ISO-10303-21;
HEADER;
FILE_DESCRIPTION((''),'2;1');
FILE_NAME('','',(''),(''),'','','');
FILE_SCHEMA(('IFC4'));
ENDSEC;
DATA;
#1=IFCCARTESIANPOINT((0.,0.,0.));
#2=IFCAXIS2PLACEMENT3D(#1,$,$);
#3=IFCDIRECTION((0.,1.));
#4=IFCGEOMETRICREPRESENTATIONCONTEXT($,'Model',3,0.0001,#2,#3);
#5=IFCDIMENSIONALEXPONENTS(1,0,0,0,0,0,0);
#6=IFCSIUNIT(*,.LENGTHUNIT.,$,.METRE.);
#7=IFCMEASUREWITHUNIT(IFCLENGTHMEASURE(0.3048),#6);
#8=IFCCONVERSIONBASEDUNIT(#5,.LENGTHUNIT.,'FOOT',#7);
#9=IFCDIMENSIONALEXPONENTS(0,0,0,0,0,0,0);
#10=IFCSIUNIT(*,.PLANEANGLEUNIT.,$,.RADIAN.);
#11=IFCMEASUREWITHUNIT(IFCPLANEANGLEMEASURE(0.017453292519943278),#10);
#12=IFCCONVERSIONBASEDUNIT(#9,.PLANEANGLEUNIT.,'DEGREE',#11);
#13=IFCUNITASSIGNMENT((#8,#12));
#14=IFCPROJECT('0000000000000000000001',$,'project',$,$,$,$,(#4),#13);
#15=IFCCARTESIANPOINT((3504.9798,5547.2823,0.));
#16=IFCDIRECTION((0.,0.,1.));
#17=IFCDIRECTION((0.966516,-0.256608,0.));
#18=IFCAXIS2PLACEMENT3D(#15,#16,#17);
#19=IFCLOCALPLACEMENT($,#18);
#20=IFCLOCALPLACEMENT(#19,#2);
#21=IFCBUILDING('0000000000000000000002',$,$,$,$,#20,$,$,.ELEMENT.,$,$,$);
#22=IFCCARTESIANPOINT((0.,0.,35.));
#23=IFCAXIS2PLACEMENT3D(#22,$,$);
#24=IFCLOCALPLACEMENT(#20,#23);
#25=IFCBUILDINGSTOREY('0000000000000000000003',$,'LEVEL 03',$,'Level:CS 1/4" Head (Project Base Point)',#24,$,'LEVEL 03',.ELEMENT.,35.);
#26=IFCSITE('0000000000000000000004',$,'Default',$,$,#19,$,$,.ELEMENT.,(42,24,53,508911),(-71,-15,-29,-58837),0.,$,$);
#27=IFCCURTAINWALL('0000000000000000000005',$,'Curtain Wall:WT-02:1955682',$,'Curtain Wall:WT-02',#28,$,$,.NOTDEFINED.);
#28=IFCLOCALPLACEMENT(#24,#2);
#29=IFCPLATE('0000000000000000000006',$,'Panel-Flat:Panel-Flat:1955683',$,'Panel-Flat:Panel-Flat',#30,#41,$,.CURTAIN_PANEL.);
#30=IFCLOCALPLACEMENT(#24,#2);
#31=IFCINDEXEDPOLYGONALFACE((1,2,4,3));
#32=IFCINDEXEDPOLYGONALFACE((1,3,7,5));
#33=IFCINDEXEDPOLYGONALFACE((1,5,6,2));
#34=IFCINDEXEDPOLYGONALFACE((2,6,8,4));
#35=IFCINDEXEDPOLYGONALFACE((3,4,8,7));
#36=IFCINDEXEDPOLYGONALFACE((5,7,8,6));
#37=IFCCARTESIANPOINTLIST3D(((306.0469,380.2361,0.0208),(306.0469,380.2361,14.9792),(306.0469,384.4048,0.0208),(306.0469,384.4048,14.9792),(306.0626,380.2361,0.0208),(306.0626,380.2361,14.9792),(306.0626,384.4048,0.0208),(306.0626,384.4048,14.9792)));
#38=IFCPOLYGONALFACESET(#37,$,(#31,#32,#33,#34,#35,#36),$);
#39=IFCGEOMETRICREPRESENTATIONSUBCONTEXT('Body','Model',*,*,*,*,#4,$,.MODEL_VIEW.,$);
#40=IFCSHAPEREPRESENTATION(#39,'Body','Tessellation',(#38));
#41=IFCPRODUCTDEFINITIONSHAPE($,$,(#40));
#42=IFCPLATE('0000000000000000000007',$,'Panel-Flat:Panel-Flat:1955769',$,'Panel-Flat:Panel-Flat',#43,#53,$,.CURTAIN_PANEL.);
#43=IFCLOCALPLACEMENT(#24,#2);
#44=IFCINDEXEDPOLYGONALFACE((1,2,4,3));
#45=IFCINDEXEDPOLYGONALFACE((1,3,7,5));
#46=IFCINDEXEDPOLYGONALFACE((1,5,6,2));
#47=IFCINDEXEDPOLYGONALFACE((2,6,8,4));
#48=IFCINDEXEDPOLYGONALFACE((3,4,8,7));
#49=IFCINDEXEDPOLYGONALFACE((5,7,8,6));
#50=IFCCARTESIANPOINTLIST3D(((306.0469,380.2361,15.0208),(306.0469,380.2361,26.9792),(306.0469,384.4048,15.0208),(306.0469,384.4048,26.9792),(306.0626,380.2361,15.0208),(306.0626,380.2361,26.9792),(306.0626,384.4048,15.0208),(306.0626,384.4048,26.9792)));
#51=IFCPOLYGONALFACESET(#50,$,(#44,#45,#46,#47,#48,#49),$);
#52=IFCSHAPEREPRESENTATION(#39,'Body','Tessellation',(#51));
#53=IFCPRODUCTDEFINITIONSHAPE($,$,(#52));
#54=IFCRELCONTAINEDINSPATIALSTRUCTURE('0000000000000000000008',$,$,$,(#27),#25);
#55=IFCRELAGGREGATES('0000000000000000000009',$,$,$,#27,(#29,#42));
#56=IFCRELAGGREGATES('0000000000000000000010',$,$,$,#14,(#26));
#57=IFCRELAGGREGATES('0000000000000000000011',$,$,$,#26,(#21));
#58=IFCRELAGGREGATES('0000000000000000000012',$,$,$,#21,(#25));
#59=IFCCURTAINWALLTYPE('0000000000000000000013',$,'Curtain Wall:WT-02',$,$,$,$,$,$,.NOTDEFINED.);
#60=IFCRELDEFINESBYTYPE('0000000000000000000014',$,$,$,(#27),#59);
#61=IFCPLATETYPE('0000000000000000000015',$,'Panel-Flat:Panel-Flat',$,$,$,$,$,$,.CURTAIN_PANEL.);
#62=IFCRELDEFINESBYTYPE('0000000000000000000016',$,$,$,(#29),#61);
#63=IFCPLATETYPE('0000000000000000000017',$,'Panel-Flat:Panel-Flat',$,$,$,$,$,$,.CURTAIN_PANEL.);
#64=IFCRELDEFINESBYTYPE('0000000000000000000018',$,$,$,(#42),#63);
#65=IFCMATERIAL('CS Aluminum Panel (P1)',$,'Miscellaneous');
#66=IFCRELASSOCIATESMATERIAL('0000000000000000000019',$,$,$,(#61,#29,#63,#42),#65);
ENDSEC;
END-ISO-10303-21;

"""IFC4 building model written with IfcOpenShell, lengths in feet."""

from ifc_helpers import new_model, entity, si_unit, converted_unit, direction, frame, origin, place, context, subcontext, project, spatial, indexed_curve, outline, extrude, source, transform, mapped, material, type_object, type_shapes, element, aggregate, save


model = new_model("IFC4")

# Units and contexts
model_context = context("Model", 3, precision=0.0001, world=origin(), true_north=direction((0.0, 1.0)))
body_context = subcontext(model_context, "Body", "Model", "MODEL_VIEW")
ifc_project = project(units=[converted_unit("LENGTHUNIT", "FOOT", entity("IfcLengthMeasure", 0.3048), si_unit("LENGTHUNIT", "METRE"), dimensions=[1, 0, 0, 0, 0, 0, 0]), converted_unit("PLANEANGLEUNIT", "DEGREE", entity("IfcPlaneAngleMeasure", 0.017453292519943278), si_unit("PLANEANGLEUNIT", "RADIAN"), dimensions=[0, 0, 0, 0, 0, 0, 0])], contexts=[model_context])

# Site, building, storey
site_placement = place(None, frame((3504.9798, 5547.2823, 0.0), z_axis=(0.0, 0.0, 1.0), x_axis=(0.966516, -0.256608, 0.0)))
site = spatial("IfcSite", under=ifc_project, at=site_placement, Name="Default", CompositionType="ELEMENT", RefLatitude=(42, 24, 53, 508911), RefLongitude=(-71, -15, -29, -58837), RefElevation=0.0)
building_placement = place(site_placement, origin())
building = spatial("IfcBuilding", under=site, at=building_placement, CompositionType="ELEMENT")
storey_placement = place(building_placement, frame((0.0, 0.0, 35.0)))
storey = spatial("IfcBuildingStorey", under=building, at=storey_placement, Name="LEVEL 03", ObjectType="Level:CS 1/4\" Head (Project Base Point)", LongName="LEVEL 03", CompositionType="ELEMENT", Elevation=35.0)

# Curtain wall, plates
curtain_wall_type = type_object("IfcCurtainWallType", Name="Curtain Wall:WT-02", PredefinedType="NOTDEFINED")
ifc_material_1 = material(Name="CS Aluminum Panel (P1)", Category="Miscellaneous")
curtain_wall_1_placement = place(storey_placement, frame((0.0, 0.0, -35.0)))
curtain_wall_1 = element("IfcCurtainWall", 1, at=curtain_wall_1_placement, inside=storey, type_object=curtain_wall_type, Name="Curtain Wall:WT-02:1955682", ObjectType="Curtain Wall:WT-02", PredefinedType="NOTDEFINED")
plate_type_1 = type_object("IfcPlateType", Name="Panel-Flat:Panel-Flat", PredefinedType="CURTAIN_PANEL", material=ifc_material_1)
shared_shape_1 = source(origin(), body_context, "Body", "SweptSolid", [
    extrude(outline(indexed_curve([(-0.0078, -2.0843), (0.0078, -2.0843), (0.0078, 2.0843), (-0.0078, 2.0843), (-0.0078, -2.0843)], self_intersect=False)), frame((0.0, -0.0078, 0.0208), z_axis=(0.0, 0.0, 1.0), x_axis=(0.0, -1.0, 0.0)), (0.0, 0.0, 1.0), 14.9583),
])
type_shapes(plate_type_1, [shared_shape_1])
plate_1_placement = place(curtain_wall_1_placement, frame((306.0469, 382.3205, 35.0), z_axis=(0.0, 0.0, 1.0), x_axis=(0.0, 1.0, 0.0)))
plate_1 = element("IfcPlate", 2, at=plate_1_placement, type_object=plate_type_1, material=ifc_material_1, Name="Panel-Flat:Panel-Flat:1955683", ObjectType="Panel-Flat:Panel-Flat", PredefinedType="CURTAIN_PANEL", context=body_context, shape_type="MappedRepresentation", body=[
    mapped(shared_shape_1, transform((0.0, 0.0, 0.0), scale=1.0)),
])
plate_type_2 = type_object("IfcPlateType", Name="Panel-Flat:Panel-Flat", PredefinedType="CURTAIN_PANEL", material=ifc_material_1)
shared_shape_2 = source(origin(), body_context, "Body", "SweptSolid", [
    extrude(outline(indexed_curve([(-0.0078, -2.0843), (0.0078, -2.0843), (0.0078, 2.0843), (-0.0078, 2.0843), (-0.0078, -2.0843)], self_intersect=False)), frame((0.0, -0.0078, 0.0208), z_axis=(0.0, 0.0, 1.0), x_axis=(0.0, -1.0, 0.0)), (0.0, 0.0, 1.0), 11.9583),
])
type_shapes(plate_type_2, [shared_shape_2])
plate_2_placement = place(curtain_wall_1_placement, frame((306.0469, 382.3205, 50.0), z_axis=(0.0, 0.0, 1.0), x_axis=(0.0, 1.0, 0.0)))
plate_2 = element("IfcPlate", 3, at=plate_2_placement, type_object=plate_type_2, material=ifc_material_1, Name="Panel-Flat:Panel-Flat:1955769", ObjectType="Panel-Flat:Panel-Flat", PredefinedType="CURTAIN_PANEL", context=body_context, shape_type="MappedRepresentation", body=[
    mapped(shared_shape_2, transform((0.0, 0.0, 0.0), scale=1.0)),
])
aggregate(curtain_wall_1, [plate_1, plate_2])

save(model, "model.ifc")
